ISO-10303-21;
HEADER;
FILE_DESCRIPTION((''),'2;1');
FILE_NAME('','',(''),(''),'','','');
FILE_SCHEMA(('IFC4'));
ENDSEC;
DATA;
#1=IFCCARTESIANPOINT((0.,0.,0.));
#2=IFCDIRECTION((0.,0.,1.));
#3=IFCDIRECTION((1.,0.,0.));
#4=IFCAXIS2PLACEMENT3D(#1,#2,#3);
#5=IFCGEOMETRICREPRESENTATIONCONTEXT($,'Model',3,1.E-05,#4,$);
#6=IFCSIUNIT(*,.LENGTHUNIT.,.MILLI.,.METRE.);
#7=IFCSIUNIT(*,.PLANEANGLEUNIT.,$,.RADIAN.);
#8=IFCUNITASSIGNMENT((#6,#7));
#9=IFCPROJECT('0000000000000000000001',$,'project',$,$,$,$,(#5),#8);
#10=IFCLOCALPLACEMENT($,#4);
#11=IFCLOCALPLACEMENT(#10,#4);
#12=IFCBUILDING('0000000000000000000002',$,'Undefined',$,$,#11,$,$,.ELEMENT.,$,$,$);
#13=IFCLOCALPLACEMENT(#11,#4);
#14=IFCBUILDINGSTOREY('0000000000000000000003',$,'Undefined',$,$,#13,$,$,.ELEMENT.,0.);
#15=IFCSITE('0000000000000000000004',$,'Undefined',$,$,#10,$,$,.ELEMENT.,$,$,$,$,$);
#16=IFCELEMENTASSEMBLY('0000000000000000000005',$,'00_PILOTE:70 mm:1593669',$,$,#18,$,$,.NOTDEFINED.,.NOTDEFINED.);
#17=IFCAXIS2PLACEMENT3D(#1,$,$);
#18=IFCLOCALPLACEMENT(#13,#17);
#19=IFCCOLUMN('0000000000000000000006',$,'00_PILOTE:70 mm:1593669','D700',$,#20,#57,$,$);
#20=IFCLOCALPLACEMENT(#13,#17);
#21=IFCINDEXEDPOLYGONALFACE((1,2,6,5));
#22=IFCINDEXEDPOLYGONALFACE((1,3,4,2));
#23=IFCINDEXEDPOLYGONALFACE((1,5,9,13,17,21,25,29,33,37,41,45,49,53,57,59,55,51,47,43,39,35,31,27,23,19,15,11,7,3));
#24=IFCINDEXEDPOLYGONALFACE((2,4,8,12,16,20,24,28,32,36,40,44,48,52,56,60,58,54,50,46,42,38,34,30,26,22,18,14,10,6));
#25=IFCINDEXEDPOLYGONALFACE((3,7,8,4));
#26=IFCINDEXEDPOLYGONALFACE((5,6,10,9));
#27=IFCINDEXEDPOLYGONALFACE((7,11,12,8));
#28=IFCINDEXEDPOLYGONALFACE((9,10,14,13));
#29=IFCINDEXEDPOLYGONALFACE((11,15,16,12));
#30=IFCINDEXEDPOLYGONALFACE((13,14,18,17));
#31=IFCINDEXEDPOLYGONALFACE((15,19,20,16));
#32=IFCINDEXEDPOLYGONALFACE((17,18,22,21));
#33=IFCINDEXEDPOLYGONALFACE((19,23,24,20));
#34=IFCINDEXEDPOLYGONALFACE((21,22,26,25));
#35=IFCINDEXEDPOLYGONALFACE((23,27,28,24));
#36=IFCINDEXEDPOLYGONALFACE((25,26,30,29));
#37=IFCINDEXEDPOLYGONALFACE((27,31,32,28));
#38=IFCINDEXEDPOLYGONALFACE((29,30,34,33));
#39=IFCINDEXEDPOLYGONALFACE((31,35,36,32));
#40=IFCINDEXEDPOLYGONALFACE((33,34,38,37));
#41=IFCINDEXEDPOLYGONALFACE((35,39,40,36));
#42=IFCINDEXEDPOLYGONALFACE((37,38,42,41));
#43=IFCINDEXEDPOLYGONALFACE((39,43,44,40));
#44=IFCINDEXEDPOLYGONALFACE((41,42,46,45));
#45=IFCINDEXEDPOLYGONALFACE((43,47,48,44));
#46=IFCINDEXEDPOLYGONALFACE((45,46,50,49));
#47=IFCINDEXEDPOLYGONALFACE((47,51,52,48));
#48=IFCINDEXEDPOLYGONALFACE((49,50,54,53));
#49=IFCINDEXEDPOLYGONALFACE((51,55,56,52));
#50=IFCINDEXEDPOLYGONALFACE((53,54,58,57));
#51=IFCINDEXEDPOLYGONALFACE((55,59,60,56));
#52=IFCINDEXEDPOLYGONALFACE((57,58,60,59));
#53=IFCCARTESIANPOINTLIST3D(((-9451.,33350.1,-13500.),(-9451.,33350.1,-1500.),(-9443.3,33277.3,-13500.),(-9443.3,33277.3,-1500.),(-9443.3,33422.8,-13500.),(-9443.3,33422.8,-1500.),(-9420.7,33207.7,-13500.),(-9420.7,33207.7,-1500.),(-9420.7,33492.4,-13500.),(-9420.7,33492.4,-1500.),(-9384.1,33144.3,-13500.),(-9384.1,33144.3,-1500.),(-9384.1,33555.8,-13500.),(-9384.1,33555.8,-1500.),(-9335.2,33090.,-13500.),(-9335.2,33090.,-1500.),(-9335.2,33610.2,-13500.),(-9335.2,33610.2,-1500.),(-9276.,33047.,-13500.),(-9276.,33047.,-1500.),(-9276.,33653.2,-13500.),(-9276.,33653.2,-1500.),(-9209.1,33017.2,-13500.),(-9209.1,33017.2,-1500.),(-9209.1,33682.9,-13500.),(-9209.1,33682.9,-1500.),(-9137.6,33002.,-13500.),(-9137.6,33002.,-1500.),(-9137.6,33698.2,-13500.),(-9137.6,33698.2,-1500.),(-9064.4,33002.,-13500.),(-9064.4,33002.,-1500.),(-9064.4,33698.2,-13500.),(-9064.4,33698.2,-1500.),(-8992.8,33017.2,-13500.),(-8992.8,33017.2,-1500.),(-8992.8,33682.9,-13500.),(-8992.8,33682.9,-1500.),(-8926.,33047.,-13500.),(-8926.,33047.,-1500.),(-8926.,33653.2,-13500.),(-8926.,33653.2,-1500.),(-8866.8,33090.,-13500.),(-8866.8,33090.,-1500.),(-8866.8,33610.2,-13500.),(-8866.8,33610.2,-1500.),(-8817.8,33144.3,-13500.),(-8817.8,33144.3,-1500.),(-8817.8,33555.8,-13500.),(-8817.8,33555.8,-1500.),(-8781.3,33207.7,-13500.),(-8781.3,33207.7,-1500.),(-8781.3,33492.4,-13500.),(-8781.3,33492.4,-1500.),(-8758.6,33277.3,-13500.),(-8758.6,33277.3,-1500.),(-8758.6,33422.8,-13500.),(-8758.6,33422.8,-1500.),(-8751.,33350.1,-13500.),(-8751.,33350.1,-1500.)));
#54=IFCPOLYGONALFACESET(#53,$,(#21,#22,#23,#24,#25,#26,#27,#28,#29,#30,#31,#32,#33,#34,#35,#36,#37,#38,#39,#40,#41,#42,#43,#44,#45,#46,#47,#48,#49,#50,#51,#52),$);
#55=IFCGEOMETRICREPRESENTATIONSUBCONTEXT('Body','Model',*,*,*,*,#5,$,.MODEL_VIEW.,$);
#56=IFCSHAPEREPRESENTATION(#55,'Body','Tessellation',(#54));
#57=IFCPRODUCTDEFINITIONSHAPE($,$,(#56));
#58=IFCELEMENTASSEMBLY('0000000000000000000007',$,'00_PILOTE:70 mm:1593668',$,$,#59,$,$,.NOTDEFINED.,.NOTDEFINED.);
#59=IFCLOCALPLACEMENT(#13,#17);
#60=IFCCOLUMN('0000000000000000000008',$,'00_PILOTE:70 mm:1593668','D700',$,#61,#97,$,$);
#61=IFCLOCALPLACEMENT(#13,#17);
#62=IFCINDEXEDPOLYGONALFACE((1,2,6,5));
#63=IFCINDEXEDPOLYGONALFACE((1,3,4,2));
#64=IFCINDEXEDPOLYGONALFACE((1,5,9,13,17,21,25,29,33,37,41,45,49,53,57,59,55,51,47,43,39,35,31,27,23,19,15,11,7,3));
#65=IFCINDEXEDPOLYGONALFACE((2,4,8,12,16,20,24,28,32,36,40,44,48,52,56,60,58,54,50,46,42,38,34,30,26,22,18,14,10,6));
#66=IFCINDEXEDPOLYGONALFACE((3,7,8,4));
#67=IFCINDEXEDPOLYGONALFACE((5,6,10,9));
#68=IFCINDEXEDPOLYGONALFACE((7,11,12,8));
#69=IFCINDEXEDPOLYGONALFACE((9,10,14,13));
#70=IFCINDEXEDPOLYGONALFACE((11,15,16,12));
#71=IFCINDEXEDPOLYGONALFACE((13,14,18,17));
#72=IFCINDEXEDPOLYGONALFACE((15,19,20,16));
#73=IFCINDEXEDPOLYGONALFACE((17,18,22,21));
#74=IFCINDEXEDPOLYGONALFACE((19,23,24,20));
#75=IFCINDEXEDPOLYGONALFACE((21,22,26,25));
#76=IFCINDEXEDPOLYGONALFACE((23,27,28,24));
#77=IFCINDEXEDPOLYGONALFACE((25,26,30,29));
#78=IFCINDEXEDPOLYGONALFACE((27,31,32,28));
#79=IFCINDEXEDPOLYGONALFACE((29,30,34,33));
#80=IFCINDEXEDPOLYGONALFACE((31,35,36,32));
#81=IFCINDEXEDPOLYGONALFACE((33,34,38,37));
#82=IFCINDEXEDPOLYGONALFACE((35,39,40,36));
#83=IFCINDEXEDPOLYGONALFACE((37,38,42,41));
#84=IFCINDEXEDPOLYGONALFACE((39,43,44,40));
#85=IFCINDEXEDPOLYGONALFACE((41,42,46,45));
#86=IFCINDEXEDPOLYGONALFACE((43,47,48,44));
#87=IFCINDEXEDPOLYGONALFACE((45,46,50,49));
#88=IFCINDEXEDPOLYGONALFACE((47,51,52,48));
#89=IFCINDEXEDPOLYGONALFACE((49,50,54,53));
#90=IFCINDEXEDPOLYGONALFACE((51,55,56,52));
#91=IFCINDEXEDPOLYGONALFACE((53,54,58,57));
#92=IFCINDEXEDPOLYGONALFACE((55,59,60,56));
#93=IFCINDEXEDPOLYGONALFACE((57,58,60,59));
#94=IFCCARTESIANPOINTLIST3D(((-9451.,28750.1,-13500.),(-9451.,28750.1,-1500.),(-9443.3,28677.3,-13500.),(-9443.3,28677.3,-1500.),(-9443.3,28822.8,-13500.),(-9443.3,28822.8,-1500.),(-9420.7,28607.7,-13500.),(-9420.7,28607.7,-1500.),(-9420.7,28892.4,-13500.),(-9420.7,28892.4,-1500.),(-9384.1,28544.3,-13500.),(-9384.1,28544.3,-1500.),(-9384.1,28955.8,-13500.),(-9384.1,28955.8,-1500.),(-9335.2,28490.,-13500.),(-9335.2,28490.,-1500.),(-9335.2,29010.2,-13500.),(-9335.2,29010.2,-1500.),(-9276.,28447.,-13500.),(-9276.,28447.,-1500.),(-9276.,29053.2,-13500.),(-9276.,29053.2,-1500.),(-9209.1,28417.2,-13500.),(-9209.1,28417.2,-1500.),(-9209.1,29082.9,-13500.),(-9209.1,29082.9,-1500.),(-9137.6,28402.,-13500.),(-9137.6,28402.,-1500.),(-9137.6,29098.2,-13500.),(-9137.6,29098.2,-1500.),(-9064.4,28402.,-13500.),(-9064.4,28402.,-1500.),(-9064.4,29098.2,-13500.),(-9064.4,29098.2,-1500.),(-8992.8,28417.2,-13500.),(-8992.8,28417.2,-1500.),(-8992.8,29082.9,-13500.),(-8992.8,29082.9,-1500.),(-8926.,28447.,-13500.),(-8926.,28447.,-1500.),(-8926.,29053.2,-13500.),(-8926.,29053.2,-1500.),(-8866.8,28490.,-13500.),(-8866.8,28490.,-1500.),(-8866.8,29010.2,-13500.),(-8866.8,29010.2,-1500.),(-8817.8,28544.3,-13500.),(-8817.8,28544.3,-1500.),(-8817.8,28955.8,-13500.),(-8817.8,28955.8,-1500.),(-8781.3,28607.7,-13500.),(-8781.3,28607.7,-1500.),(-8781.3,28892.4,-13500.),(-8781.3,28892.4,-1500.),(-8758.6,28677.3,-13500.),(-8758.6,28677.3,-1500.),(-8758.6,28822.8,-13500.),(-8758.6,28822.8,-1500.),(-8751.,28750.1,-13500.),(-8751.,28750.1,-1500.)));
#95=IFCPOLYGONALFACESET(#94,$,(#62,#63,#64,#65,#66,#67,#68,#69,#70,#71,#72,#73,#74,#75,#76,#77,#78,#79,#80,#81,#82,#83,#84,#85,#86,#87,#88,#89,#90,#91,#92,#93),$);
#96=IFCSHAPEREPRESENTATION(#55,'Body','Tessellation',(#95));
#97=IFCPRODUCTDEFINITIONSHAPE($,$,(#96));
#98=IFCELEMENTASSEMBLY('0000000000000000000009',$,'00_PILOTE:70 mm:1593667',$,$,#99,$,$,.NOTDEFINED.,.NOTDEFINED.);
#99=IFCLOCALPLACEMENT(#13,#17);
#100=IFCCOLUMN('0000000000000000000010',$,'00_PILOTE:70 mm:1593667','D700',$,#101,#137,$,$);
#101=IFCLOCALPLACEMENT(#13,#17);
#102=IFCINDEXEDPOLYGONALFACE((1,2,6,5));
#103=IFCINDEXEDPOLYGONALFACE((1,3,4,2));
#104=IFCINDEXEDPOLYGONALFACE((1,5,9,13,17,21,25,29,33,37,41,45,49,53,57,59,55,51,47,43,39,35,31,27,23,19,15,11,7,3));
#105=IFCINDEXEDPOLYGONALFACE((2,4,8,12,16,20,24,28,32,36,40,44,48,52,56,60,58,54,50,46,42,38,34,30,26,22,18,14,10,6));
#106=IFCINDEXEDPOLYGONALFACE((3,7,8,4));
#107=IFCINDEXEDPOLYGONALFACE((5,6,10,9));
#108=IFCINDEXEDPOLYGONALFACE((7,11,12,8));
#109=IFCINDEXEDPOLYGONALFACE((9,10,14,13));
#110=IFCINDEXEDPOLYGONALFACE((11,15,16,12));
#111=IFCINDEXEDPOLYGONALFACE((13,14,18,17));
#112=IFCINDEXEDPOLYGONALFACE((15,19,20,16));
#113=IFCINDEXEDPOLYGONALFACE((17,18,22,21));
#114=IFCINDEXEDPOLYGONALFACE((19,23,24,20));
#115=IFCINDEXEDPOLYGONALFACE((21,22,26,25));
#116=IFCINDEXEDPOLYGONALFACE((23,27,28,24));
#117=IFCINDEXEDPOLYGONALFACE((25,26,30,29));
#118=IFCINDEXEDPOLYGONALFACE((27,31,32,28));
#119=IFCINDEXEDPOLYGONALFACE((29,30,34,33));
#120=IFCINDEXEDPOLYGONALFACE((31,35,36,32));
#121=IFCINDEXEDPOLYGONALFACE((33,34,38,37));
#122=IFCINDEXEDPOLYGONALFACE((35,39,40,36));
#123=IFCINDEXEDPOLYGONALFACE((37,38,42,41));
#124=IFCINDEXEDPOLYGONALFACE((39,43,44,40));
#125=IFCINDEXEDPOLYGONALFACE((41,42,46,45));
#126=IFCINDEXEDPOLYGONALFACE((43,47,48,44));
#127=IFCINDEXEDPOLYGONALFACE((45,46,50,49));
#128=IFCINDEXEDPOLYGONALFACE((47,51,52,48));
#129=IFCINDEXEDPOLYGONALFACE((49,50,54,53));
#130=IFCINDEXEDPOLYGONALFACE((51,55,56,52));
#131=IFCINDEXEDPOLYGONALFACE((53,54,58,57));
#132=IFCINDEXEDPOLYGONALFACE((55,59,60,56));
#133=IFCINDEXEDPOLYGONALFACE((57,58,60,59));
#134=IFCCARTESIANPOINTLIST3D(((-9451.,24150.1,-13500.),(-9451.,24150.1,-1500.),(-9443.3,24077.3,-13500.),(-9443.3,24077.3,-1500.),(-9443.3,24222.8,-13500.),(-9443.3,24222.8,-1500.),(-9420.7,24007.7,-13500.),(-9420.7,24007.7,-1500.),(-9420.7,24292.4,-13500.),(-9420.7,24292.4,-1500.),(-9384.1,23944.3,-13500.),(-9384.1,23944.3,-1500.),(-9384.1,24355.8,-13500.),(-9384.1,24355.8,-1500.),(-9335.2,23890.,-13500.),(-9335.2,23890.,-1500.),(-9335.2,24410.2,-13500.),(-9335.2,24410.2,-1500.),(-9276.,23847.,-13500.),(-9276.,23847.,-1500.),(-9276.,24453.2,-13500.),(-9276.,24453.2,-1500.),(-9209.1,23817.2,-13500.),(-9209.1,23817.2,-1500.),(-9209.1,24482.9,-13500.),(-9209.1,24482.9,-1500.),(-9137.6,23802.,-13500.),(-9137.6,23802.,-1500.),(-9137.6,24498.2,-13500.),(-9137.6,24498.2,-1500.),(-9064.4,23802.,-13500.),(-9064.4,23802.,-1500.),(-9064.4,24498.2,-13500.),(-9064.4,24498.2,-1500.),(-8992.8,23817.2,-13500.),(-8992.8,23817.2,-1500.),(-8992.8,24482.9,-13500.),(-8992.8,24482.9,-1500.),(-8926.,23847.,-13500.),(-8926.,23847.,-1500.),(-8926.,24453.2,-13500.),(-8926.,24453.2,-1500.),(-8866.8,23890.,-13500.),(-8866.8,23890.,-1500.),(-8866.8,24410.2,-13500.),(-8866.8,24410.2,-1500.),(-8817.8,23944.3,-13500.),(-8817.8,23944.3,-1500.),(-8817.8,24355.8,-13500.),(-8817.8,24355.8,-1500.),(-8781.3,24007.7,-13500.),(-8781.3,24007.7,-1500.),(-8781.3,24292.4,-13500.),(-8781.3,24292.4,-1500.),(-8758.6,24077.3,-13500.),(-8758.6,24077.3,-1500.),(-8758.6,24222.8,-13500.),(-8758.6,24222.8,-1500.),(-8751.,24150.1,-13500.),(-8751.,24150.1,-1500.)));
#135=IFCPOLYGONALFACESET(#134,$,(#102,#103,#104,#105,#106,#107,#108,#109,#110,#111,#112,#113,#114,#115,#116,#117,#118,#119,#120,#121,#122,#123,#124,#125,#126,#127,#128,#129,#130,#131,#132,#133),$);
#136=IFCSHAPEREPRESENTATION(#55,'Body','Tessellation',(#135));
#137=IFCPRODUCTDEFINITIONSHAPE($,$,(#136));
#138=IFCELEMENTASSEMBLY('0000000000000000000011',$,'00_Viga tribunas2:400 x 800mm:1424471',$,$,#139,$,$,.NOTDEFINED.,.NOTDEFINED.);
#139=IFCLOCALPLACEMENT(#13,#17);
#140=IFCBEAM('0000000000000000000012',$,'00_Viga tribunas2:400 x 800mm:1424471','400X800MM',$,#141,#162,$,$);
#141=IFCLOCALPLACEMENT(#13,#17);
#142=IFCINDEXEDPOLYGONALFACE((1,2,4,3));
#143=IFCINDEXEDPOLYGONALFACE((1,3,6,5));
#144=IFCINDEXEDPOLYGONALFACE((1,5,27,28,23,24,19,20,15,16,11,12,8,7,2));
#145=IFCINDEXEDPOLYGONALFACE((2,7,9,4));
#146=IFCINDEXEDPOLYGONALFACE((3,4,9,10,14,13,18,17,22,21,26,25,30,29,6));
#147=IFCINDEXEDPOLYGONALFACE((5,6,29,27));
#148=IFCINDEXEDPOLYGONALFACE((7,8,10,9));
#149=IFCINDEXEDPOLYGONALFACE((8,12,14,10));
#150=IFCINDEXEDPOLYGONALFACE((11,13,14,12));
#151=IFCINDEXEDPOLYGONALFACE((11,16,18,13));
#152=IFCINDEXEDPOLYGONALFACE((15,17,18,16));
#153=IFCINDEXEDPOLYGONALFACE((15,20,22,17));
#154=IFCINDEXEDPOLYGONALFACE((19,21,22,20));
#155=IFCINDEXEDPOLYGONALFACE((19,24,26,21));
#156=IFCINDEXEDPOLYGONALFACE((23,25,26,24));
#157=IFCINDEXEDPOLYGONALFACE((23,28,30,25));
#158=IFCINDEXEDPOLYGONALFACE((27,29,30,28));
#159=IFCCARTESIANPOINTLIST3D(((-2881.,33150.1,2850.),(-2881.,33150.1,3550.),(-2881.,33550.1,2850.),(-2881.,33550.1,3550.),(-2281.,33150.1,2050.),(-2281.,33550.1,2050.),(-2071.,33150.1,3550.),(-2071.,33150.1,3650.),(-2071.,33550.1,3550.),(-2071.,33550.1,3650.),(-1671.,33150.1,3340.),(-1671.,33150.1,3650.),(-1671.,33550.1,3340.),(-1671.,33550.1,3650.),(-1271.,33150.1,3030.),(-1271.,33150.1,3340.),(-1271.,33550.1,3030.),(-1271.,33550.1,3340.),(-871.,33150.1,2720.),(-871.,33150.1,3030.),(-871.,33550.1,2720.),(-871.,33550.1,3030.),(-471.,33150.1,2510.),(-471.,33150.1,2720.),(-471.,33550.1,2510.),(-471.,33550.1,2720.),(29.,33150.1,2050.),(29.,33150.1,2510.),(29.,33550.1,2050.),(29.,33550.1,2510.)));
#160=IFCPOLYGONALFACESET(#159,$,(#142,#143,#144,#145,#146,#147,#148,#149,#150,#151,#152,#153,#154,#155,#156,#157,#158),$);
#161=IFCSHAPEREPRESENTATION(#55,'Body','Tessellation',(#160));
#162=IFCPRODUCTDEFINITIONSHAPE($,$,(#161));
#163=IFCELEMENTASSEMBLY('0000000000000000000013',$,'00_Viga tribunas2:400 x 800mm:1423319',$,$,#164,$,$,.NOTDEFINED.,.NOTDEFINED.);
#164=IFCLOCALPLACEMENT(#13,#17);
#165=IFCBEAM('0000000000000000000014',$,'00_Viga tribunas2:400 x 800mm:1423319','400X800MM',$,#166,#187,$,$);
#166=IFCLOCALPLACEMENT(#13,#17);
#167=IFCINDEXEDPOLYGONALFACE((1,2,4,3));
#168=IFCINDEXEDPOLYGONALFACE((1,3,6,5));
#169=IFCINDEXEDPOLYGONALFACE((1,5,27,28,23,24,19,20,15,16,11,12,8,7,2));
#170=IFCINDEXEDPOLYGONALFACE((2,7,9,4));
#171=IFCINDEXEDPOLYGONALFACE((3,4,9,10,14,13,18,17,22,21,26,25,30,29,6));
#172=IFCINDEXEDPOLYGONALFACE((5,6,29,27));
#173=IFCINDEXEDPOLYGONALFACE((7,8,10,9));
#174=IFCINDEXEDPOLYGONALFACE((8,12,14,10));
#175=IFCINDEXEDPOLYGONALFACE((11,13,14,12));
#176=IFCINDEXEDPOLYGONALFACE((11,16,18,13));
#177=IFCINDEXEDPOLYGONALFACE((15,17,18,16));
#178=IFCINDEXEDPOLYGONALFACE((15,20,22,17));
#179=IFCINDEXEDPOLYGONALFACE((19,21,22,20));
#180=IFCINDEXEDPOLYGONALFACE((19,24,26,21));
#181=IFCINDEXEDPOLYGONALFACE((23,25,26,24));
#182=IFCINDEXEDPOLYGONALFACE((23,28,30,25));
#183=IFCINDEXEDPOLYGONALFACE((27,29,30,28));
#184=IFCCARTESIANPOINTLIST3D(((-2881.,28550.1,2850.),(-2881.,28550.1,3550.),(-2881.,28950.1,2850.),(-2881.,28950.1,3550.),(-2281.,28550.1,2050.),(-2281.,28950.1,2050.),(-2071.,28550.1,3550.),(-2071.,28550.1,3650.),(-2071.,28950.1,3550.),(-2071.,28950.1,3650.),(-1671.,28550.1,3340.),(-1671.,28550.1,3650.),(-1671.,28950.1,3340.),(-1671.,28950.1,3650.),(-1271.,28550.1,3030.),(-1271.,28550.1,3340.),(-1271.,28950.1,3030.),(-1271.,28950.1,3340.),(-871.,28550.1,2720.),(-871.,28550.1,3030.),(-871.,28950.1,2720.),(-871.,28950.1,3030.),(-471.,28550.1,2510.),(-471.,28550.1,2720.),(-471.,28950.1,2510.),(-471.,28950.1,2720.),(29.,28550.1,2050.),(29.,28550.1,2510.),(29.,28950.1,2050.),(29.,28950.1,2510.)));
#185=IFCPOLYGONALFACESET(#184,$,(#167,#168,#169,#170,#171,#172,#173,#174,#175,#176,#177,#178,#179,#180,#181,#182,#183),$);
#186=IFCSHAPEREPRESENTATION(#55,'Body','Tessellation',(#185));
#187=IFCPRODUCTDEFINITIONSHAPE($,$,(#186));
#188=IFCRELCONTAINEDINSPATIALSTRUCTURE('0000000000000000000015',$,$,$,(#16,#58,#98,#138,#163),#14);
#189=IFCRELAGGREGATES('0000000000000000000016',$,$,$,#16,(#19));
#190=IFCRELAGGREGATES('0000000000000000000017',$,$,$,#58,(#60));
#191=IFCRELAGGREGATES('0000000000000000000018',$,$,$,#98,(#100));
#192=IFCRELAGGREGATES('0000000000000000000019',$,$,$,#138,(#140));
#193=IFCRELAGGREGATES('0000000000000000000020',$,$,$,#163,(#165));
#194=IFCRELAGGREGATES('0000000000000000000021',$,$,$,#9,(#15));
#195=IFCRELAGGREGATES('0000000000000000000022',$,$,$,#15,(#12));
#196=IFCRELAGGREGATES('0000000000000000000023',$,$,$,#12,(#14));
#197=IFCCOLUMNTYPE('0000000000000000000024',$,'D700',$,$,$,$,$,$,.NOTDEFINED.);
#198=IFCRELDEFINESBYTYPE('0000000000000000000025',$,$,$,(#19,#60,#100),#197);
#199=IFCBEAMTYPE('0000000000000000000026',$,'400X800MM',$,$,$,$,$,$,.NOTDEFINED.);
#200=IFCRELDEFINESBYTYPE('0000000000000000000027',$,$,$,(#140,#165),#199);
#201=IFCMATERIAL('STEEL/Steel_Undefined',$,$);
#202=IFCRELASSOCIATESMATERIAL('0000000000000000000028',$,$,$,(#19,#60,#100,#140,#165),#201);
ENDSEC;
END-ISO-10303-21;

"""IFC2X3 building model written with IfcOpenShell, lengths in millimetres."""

from ifc_helpers import new_model, si_unit, frame, origin_with_axes, origin_2d_with_axis, place, context, subcontext, project, spatial, polyline, circle, outline, extrude, material, type_object, element, aggregate, save


model = new_model("IFC2X3")

# Units and contexts
model_context = context("Model", 3, precision=1e-05, world=origin_with_axes())
body_context = subcontext(model_context, "Body", "Model", "MODEL_VIEW")
ifc_project = project(units=[si_unit("LENGTHUNIT", "METRE", prefix="MILLI"), si_unit("PLANEANGLEUNIT", "RADIAN")], contexts=[model_context])

# Site, building, storey
site_placement = place(None, origin_with_axes())
site = spatial("IfcSite", under=ifc_project, at=site_placement, Name="Undefined", CompositionType="ELEMENT")
building_placement = place(site_placement, origin_with_axes())
building = spatial("IfcBuilding", under=site, at=building_placement, Name="Undefined", CompositionType="ELEMENT")
storey_placement = place(building_placement, origin_with_axes())
storey = spatial("IfcBuildingStorey", under=building, at=storey_placement, Name="Undefined", CompositionType="ELEMENT", Elevation=0.0)

# Element assemblies, columns
ifc_material_1 = material(Name="STEEL/Steel_Undefined")
column_type_1 = type_object("IfcColumnType", Name="D700", PredefinedType="NOTDEFINED")
assembly_1_placement = place(storey_placement, origin_with_axes())
assembly_1 = element("IfcElementAssembly", 1, at=assembly_1_placement, inside=storey, Name="00_PILOTE:70 mm:1593669", AssemblyPlace="NOTDEFINED", PredefinedType="NOTDEFINED")
column_1_placement = place(assembly_1_placement, frame((-9101.0, 33350.1, -13500.0), z_axis=(0.0, 0.0, 1.0), x_axis=(0.0, 1.0, 0.0)))
column_1 = element("IfcColumn", 2, at=column_1_placement, type_object=column_type_1, material=ifc_material_1, Name="00_PILOTE:70 mm:1593669", Description="D700", context=body_context, shape_type="SweptSolid", body=[
    extrude(circle(Radius=350.0, at=origin_2d_with_axis()), frame((0.0, 0.0, 12000.0), z_axis=(0.0, 0.0, -1.0), x_axis=(0.0, 1.0, 0.0)), (0.0, 0.0, 1.0), 12000.0),
])
aggregate(assembly_1, [column_1])
assembly_2_placement = place(storey_placement, origin_with_axes())
assembly_2 = element("IfcElementAssembly", 3, at=assembly_2_placement, inside=storey, Name="00_PILOTE:70 mm:1593668", AssemblyPlace="NOTDEFINED", PredefinedType="NOTDEFINED")
column_2_placement = place(assembly_2_placement, frame((-9101.0, 28750.1, -13500.0), z_axis=(0.0, 0.0, 1.0), x_axis=(0.0, 1.0, 0.0)))
column_2 = element("IfcColumn", 4, at=column_2_placement, type_object=column_type_1, material=ifc_material_1, Name="00_PILOTE:70 mm:1593668", Description="D700", context=body_context, shape_type="SweptSolid", body=[
    extrude(circle(Radius=350.0, at=origin_2d_with_axis()), frame((0.0, 0.0, 12000.0), z_axis=(0.0, 0.0, -1.0), x_axis=(0.0, 1.0, 0.0)), (0.0, 0.0, 1.0), 12000.0),
])
aggregate(assembly_2, [column_2])
assembly_3_placement = place(storey_placement, origin_with_axes())
assembly_3 = element("IfcElementAssembly", 5, at=assembly_3_placement, inside=storey, Name="00_PILOTE:70 mm:1593667", AssemblyPlace="NOTDEFINED", PredefinedType="NOTDEFINED")
column_3_placement = place(assembly_3_placement, frame((-9101.0, 24150.1, -13500.0), z_axis=(0.0, 0.0, 1.0), x_axis=(0.0, 1.0, 0.0)))
column_3 = element("IfcColumn", 6, at=column_3_placement, type_object=column_type_1, material=ifc_material_1, Name="00_PILOTE:70 mm:1593667", Description="D700", context=body_context, shape_type="SweptSolid", body=[
    extrude(circle(Radius=350.0, at=origin_2d_with_axis()), frame((0.0, 0.0, 12000.0), z_axis=(0.0, 0.0, -1.0), x_axis=(0.0, 1.0, 0.0)), (0.0, 0.0, 1.0), 12000.0),
])
aggregate(assembly_3, [column_3])

# Element assemblies, beams
assembly_4_placement = place(storey_placement, origin_with_axes())
assembly_4 = element("IfcElementAssembly", 7, at=assembly_4_placement, inside=storey, Name="00_Viga tribunas2:400 x 800mm:1424471", AssemblyPlace="NOTDEFINED", PredefinedType="NOTDEFINED")
beam_type_1 = type_object("IfcBeamType", Name="400X800MM", PredefinedType="NOTDEFINED")
beam_1_placement = place(assembly_4_placement, frame((-1426.0, 33150.1, 2850.0), z_axis=(-1.0, 0.0, 0.0), x_axis=(0.0, 1.0, 0.0)))
beam_1 = element("IfcBeam", 8, at=beam_1_placement, type_object=beam_type_1, material=ifc_material_1, Name="00_Viga tribunas2:400 x 800mm:1424471", Description="400X800MM", context=body_context, shape_type="SweptSolid", body=[
    extrude(outline(polyline([(-800.0, 855.0), (0.0, 1455.0), (700.0, 1455.0), (700.0, 645.0), (800.0, 645.0), (800.0, 245.0), (490.0, 245.0), (490.0, -155.0), (180.0, -155.0), (180.0, -555.0), (-130.0, -555.0), (-130.0, -955.0), (-340.0, -955.0), (-340.0, -1455.0), (-800.0, -1455.0), (-800.0, 855.0)])), frame((400.0, 0.0, 0.0), z_axis=(-1.0, 0.0, 0.0), x_axis=(0.0, -1.0, 0.0)), (0.0, 0.0, 1.0), 400.0),
])
aggregate(assembly_4, [beam_1])
assembly_5_placement = place(storey_placement, origin_with_axes())
assembly_5 = element("IfcElementAssembly", 9, at=assembly_5_placement, inside=storey, Name="00_Viga tribunas2:400 x 800mm:1423319", AssemblyPlace="NOTDEFINED", PredefinedType="NOTDEFINED")
beam_2_placement = place(assembly_5_placement, frame((-1426.0, 28550.1, 2850.0), z_axis=(-1.0, 0.0, 0.0), x_axis=(0.0, 1.0, 0.0)))
beam_2 = element("IfcBeam", 10, at=beam_2_placement, type_object=beam_type_1, material=ifc_material_1, Name="00_Viga tribunas2:400 x 800mm:1423319", Description="400X800MM", context=body_context, shape_type="SweptSolid", body=[
    extrude(outline(polyline([(-800.0, 855.0), (0.0, 1455.0), (700.0, 1455.0), (700.0, 645.0), (800.0, 645.0), (800.0, 245.0), (490.0, 245.0), (490.0, -155.0), (180.0, -155.0), (180.0, -555.0), (-130.0, -555.0), (-130.0, -955.0), (-340.0, -955.0), (-340.0, -1455.0), (-800.0, -1455.0), (-800.0, 855.0)])), frame((400.0, 0.0, 0.0), z_axis=(-1.0, 0.0, 0.0), x_axis=(0.0, -1.0, 0.0)), (0.0, 0.0, 1.0), 400.0),
])
aggregate(assembly_5, [beam_2])

save(model, "model.ifc")
